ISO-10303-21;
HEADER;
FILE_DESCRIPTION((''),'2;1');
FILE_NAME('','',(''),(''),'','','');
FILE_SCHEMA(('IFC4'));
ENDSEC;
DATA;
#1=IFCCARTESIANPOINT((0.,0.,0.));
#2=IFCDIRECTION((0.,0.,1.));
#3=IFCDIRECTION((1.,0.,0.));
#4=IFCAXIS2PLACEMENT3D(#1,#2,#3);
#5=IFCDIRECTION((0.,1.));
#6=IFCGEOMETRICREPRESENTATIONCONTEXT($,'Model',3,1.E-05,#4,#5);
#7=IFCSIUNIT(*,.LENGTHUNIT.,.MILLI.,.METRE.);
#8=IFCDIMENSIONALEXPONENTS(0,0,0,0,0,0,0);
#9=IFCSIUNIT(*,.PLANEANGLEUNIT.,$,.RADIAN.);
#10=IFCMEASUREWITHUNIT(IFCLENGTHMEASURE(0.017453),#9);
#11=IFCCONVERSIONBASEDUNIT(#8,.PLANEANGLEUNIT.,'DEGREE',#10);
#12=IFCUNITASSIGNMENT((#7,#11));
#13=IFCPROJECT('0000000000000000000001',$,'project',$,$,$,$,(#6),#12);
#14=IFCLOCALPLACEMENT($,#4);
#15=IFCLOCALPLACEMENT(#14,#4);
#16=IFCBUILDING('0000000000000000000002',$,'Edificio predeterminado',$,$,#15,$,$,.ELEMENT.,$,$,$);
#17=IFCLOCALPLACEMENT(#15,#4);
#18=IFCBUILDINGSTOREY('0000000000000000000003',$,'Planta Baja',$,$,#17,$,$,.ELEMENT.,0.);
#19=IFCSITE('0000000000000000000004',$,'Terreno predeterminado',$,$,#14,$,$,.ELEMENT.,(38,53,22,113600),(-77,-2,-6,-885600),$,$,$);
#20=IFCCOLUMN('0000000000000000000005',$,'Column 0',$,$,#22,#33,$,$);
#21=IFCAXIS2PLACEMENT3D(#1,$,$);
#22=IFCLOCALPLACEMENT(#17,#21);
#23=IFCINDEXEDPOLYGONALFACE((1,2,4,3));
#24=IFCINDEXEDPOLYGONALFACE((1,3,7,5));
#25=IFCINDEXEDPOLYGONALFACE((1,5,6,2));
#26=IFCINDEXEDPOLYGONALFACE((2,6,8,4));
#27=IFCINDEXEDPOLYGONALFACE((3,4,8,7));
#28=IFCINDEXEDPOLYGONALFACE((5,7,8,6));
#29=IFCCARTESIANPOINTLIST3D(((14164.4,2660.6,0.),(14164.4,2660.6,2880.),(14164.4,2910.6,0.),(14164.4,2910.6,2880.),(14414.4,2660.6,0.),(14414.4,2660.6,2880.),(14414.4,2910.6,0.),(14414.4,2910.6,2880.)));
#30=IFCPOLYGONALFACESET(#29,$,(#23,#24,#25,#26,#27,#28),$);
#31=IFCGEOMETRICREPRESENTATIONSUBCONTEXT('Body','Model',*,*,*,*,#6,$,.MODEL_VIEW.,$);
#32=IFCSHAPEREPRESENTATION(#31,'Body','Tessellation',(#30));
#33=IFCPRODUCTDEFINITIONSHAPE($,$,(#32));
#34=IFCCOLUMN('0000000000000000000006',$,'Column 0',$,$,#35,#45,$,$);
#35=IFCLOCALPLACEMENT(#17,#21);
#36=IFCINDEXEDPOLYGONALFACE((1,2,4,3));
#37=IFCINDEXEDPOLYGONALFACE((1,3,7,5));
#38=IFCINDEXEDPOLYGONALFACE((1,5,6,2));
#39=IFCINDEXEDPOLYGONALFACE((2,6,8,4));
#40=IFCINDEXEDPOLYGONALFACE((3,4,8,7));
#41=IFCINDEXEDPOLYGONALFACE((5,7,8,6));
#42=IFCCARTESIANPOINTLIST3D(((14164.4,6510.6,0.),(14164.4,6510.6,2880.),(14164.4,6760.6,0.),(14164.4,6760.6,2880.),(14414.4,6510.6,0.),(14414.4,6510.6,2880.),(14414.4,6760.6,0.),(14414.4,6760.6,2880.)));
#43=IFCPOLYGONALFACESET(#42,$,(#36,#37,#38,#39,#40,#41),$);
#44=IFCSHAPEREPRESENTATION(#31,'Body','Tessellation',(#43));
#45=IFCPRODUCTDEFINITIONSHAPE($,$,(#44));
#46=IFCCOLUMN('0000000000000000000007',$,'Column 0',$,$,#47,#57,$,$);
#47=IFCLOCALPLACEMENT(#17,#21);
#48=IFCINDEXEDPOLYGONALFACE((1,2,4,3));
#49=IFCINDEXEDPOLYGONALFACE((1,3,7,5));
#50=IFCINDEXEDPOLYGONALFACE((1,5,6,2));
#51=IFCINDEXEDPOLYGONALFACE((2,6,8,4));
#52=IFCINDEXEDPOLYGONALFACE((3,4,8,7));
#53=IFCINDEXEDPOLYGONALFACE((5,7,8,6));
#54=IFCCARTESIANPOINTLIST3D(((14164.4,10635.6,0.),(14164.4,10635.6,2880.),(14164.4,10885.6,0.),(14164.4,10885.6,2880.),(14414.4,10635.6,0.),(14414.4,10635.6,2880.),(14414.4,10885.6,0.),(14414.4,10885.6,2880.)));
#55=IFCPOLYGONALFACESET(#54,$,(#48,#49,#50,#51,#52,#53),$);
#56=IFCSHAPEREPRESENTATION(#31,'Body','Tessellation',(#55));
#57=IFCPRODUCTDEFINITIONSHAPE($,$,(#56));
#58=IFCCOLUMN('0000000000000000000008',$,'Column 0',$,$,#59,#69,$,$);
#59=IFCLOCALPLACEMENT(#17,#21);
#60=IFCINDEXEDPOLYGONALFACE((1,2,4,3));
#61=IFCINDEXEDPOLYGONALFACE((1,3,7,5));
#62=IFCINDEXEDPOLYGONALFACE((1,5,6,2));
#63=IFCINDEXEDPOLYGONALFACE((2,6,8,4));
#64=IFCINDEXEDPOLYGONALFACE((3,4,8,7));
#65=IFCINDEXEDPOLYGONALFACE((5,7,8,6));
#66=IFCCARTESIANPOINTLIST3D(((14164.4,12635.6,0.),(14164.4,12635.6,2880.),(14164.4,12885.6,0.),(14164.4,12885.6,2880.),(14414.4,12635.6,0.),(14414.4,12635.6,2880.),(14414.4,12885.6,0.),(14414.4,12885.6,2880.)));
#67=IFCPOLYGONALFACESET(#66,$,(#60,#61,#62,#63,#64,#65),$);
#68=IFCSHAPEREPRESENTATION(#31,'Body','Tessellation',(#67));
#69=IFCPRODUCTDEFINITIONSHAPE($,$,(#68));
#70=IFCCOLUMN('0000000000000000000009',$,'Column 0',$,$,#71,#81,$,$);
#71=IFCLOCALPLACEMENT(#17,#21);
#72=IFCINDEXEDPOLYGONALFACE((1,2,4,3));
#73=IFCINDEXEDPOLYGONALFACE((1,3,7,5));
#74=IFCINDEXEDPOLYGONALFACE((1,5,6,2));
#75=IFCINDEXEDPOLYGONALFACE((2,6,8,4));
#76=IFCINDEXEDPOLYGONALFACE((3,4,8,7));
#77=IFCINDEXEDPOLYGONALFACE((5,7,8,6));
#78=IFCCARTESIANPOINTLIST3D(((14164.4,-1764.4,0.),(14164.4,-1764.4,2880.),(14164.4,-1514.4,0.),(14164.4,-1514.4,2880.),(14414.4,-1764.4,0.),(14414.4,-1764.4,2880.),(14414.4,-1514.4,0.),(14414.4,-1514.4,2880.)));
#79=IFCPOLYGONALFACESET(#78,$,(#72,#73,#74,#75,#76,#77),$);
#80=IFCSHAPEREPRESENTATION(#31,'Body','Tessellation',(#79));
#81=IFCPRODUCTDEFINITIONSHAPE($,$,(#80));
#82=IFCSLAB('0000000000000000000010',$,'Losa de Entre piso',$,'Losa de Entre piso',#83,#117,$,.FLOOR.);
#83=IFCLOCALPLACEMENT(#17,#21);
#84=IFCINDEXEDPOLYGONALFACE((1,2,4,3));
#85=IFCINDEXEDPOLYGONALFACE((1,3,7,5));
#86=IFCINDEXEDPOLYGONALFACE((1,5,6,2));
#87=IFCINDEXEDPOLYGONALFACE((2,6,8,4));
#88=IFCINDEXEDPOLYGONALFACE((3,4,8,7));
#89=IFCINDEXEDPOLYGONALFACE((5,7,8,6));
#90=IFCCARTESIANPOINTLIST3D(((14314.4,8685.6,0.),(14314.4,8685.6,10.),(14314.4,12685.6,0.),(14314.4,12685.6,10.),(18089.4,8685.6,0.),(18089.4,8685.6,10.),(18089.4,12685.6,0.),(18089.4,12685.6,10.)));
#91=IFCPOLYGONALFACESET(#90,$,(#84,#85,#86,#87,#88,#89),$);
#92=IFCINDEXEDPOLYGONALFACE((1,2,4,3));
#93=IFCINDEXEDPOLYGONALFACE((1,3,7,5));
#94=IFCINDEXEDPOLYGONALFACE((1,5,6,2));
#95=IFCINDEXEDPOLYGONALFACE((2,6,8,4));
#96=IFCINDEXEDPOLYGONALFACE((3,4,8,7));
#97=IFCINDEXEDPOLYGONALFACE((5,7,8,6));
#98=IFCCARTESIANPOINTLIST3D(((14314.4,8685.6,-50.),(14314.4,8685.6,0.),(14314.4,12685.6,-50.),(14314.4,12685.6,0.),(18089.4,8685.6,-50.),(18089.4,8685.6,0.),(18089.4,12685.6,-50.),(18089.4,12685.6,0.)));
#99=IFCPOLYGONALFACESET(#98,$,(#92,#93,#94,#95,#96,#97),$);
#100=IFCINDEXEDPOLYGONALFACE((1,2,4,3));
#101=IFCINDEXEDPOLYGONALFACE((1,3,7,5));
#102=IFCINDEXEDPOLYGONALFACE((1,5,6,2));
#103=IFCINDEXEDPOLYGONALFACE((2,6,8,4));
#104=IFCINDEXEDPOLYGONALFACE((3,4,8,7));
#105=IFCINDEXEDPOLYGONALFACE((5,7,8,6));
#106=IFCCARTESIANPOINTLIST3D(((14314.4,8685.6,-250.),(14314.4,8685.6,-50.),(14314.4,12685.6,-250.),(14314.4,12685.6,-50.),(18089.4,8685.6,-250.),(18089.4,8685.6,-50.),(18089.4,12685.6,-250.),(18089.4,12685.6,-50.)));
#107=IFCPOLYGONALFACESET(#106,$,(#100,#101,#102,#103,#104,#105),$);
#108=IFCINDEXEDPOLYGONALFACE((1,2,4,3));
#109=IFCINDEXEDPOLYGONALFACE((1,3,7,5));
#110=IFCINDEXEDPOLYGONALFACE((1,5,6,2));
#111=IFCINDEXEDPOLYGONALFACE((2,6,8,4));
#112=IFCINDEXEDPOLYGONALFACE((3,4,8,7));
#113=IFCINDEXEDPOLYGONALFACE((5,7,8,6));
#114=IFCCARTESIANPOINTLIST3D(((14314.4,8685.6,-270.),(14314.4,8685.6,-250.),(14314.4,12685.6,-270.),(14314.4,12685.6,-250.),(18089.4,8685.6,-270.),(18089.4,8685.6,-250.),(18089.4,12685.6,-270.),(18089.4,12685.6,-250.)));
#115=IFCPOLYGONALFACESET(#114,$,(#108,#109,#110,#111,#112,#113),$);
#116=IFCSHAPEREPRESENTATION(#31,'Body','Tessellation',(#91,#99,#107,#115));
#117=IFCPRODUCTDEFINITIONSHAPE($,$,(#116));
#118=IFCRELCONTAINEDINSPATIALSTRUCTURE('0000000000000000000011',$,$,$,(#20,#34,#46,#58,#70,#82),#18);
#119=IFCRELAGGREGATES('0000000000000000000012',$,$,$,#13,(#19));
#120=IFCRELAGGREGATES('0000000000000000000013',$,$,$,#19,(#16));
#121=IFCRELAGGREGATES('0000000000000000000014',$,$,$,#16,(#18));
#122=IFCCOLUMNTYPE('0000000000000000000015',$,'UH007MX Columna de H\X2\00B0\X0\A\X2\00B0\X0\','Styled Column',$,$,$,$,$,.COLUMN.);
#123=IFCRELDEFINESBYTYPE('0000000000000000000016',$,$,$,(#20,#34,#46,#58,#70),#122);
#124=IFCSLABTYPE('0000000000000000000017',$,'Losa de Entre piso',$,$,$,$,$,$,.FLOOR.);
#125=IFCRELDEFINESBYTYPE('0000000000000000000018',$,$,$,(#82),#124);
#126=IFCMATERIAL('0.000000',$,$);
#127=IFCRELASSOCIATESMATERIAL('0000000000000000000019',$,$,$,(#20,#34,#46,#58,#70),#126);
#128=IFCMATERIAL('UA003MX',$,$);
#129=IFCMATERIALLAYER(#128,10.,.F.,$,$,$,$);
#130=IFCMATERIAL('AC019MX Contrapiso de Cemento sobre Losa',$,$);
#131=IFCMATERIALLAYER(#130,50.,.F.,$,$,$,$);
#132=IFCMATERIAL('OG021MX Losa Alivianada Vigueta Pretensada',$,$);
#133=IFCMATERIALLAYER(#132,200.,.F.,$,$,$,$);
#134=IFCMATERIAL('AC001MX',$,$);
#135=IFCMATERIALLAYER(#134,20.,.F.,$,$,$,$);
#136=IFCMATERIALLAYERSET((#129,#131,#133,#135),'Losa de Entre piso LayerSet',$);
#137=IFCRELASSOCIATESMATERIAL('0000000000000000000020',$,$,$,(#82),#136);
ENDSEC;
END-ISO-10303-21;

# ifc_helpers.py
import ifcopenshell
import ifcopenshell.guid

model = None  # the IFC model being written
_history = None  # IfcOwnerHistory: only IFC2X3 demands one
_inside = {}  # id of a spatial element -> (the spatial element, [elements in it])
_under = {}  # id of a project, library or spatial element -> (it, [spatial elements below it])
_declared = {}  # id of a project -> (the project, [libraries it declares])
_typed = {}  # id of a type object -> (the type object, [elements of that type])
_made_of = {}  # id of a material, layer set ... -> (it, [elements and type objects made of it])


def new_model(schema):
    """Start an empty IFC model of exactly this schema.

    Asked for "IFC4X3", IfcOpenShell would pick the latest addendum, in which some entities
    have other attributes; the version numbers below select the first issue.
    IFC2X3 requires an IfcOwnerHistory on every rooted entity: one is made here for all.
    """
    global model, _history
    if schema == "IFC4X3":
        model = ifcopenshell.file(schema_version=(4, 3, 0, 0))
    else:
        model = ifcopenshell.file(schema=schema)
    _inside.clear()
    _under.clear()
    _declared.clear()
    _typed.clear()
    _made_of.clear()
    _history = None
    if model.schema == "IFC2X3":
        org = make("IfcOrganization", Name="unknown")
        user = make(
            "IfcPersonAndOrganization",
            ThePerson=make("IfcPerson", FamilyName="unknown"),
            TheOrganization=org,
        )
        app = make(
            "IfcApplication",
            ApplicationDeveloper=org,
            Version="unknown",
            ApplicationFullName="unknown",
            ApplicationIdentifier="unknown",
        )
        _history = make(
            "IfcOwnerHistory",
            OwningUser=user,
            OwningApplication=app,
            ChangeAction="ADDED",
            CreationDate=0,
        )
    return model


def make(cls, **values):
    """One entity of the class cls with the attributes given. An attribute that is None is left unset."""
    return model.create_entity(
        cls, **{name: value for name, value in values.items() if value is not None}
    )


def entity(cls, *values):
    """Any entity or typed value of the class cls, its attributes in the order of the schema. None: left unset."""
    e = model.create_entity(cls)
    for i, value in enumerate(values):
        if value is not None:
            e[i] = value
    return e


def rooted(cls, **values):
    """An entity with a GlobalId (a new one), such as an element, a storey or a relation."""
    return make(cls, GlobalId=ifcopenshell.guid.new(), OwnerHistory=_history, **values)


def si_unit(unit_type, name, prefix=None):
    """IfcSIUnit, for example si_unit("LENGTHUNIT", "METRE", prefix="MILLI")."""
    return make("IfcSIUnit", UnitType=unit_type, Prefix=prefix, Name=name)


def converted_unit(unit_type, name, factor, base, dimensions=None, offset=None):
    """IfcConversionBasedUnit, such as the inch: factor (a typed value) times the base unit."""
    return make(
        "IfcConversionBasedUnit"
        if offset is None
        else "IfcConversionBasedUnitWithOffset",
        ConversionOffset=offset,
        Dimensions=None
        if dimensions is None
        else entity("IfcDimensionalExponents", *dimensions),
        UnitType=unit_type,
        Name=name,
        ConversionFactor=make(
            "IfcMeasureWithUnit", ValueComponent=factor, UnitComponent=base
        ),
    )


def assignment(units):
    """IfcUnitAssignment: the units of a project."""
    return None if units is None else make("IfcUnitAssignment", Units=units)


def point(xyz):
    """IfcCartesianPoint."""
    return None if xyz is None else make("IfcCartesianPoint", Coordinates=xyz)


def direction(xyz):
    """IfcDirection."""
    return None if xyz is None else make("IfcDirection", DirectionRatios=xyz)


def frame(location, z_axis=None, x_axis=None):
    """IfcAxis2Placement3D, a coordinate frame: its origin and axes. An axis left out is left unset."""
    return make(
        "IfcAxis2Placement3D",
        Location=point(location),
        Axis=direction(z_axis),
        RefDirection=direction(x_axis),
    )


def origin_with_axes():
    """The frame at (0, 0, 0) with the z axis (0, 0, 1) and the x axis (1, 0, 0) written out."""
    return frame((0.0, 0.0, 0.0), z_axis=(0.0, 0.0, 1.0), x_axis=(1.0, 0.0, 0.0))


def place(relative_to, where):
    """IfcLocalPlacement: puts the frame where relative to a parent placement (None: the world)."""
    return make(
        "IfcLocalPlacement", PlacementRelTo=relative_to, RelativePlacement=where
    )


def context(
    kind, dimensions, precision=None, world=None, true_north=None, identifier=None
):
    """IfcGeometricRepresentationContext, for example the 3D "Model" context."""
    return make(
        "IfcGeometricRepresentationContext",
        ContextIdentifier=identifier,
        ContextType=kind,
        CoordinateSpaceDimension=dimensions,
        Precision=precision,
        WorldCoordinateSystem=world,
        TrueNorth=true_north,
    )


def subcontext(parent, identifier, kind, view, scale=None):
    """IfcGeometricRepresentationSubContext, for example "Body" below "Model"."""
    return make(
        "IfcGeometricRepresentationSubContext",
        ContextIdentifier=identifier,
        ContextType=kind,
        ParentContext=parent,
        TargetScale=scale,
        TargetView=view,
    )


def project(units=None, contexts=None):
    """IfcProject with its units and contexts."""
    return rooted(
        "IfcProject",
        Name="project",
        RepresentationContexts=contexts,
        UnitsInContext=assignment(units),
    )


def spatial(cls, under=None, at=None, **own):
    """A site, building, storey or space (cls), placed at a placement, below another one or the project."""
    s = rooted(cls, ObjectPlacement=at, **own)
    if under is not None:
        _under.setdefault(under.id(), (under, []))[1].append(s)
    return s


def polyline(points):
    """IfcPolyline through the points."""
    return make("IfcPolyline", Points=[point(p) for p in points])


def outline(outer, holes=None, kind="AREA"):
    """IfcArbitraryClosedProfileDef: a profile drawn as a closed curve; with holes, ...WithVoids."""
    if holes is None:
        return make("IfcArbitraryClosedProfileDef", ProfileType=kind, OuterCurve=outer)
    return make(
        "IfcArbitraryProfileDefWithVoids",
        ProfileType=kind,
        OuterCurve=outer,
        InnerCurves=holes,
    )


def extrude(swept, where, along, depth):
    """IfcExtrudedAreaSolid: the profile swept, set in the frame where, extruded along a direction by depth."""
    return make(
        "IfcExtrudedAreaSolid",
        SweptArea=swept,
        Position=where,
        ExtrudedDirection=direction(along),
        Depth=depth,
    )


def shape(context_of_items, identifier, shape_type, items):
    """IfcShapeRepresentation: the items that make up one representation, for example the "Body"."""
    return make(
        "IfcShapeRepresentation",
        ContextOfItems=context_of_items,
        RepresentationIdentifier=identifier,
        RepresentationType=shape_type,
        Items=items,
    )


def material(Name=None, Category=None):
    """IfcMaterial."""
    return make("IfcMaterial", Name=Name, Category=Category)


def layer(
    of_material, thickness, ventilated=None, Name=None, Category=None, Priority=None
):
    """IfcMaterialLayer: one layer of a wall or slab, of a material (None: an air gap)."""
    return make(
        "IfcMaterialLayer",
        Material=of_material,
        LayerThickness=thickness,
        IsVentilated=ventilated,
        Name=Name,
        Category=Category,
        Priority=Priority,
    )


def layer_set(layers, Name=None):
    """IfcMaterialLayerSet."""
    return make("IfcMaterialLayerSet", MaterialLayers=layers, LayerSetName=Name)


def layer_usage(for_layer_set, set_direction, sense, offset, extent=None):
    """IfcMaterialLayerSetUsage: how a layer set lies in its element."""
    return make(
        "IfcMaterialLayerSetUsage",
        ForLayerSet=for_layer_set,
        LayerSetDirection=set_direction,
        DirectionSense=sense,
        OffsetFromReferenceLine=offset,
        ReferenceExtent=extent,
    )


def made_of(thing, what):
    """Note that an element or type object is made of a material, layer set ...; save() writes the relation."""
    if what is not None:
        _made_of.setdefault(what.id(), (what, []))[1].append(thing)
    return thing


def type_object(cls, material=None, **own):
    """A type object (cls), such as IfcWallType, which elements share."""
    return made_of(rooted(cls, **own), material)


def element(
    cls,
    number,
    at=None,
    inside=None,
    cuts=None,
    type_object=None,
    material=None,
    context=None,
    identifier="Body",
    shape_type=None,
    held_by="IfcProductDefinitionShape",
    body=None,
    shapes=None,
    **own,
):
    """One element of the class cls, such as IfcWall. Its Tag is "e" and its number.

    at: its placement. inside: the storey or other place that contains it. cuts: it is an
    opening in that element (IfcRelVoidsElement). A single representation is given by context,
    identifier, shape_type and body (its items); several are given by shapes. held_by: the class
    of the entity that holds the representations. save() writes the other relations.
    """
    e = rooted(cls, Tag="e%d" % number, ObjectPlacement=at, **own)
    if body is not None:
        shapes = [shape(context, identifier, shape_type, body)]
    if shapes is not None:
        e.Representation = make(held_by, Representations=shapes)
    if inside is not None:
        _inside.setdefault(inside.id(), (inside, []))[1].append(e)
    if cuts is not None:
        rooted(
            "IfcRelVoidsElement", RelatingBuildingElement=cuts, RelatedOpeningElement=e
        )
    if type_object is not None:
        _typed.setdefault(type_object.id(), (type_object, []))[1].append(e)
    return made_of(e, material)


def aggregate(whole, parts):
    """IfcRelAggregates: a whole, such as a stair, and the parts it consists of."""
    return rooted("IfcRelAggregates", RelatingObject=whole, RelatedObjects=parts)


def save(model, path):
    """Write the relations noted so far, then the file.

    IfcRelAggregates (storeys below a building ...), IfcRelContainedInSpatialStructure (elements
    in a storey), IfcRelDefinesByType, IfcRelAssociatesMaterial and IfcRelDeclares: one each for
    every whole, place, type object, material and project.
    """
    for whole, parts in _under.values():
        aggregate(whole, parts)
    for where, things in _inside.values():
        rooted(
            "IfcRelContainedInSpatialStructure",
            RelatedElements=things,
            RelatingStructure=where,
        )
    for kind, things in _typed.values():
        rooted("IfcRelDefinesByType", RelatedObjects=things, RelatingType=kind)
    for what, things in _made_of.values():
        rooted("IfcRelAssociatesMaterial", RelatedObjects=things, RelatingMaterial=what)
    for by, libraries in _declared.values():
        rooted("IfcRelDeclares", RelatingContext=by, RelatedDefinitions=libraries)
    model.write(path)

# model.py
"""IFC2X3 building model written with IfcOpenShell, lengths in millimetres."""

from ifc_helpers import new_model, entity, si_unit, converted_unit, direction, frame, origin_with_axes, place, context, subcontext, project, spatial, polyline, outline, extrude, material, layer, layer_set, layer_usage, type_object, element, save


model = new_model("IFC2X3")

# Units and contexts
model_context = context("Model", 3, precision=1e-05, world=origin_with_axes(), true_north=direction((0.0, 1.0)))
body_context = subcontext(model_context, "Body", "Model", "MODEL_VIEW")
ifc_project = project(units=[si_unit("LENGTHUNIT", "METRE", prefix="MILLI"), converted_unit("PLANEANGLEUNIT", "DEGREE", entity("IfcLengthMeasure", 0.017453), si_unit("PLANEANGLEUNIT", "RADIAN"), dimensions=[0, 0, 0, 0, 0, 0, 0])], contexts=[model_context])

# Site, building, storey
site_placement = place(None, origin_with_axes())
site = spatial("IfcSite", under=ifc_project, at=site_placement, Name="Terreno predeterminado", CompositionType="ELEMENT", RefLatitude=(38, 53, 22, 113600), RefLongitude=(-77, -2, -6, -885600))
building_placement = place(site_placement, origin_with_axes())
building = spatial("IfcBuilding", under=site, at=building_placement, Name="Edificio predeterminado", CompositionType="ELEMENT")
storey_placement = place(building_placement, origin_with_axes())
storey = spatial("IfcBuildingStorey", under=building, at=storey_placement, Name="Planta Baja", CompositionType="ELEMENT", Elevation=0.0)

# Columns
ifc_material_1 = material(Name="0.000000")
column_type = type_object("IfcColumnType", Name="UH007MX Columna de H°A°", Description="Styled Column", PredefinedType="COLUMN")
for number, where, z_axis, x_axis, name in (
    (1, (14289.4, 2785.6, 0.0), (0.0, 0.0, 1.0), (1.0, 0.0, 0.0), "Column 0"),
    (2, (14289.4, 6635.6, 0.0), (0.0, 0.0, 1.0), (1.0, 0.0, 0.0), "Column 0"),
    (3, (14289.4, 10760.6, 0.0), (0.0, 0.0, 1.0), (1.0, 0.0, 0.0), "Column 0"),
    (4, (14289.4, 12760.6, 0.0), (0.0, 0.0, 1.0), (1.0, 0.0, 0.0), "Column 0"),
    (5, (14289.4, -1639.4, 0.0), (0.0, 0.0, 1.0), (1.0, 0.0, 0.0), "Column 0"),
):
    element("IfcColumn", number, at=place(storey_placement, frame(where, z_axis=z_axis, x_axis=x_axis)), inside=storey, type_object=column_type, material=ifc_material_1, Name=name, context=body_context, shape_type="SweptSolid", body=[
        extrude(outline(polyline([(-125.0, -125.0), (125.0, -125.0), (125.0, 125.0), (-125.0, 125.0), (-125.0, -125.0)])), origin_with_axes(), (0.0, 0.0, 1.0), 2880.0),
    ])

# Slab
ifc_material_2 = material(Name="UA003MX")
ifc_layer_1 = layer(ifc_material_2, 10.0, ventilated=False)
ifc_material_3 = material(Name="AC019MX Contrapiso de Cemento sobre Losa")
ifc_layer_2 = layer(ifc_material_3, 50.0, ventilated=False)
ifc_material_4 = material(Name="OG021MX Losa Alivianada Vigueta Pretensada")
ifc_layer_3 = layer(ifc_material_4, 200.0, ventilated=False)
ifc_material_5 = material(Name="AC001MX")
ifc_layer_4 = layer(ifc_material_5, 20.0, ventilated=False)
ifc_layer_set_1 = layer_set([ifc_layer_1, ifc_layer_2, ifc_layer_3, ifc_layer_4], Name="Losa de Entre piso LayerSet")
ifc_layer_usage_1 = layer_usage(ifc_layer_set_1, "AXIS3", "NEGATIVE", 0.0)
slab_type = type_object("IfcSlabType", Name="Losa de Entre piso", PredefinedType="FLOOR")
slab_1_placement = place(storey_placement, origin_with_axes())
element("IfcSlab", 6, at=slab_1_placement, inside=storey, type_object=slab_type, material=ifc_layer_usage_1, Name="Losa de Entre piso", ObjectType="Losa de Entre piso", PredefinedType="FLOOR", context=body_context, shape_type="SweptSolid", body=[
    extrude(outline(polyline([(0.0, 4000.0), (3775.0, 4000.0), (3775.0, 0.0), (0.0, 0.0), (0.0, 4000.0)])), frame((14314.4, 12685.6, 0.0), z_axis=(0.0, 0.0, -1.0), x_axis=(1.0, 0.0, 0.0)), (0.0, 0.0, -1.0), 10.0),
    extrude(outline(polyline([(0.0, 4000.0), (3775.0, 4000.0), (3775.0, 0.0), (0.0, 0.0), (0.0, 4000.0)])), frame((14314.4, 12685.6, -50.0), z_axis=(0.0, 0.0, -1.0), x_axis=(1.0, 0.0, 0.0)), (0.0, 0.0, -1.0), 50.0),
    extrude(outline(polyline([(0.0, 4000.0), (3775.0, 4000.0), (3775.0, 0.0), (0.0, 0.0), (0.0, 4000.0)])), frame((14314.4, 12685.6, -250.0), z_axis=(0.0, 0.0, -1.0), x_axis=(1.0, 0.0, 0.0)), (0.0, 0.0, -1.0), 200.0),
    extrude(outline(polyline([(0.0, 4000.0), (3775.0, 4000.0), (3775.0, 0.0), (0.0, 0.0), (0.0, 4000.0)])), frame((14314.4, 12685.6, -270.0), z_axis=(0.0, 0.0, -1.0), x_axis=(1.0, 0.0, 0.0)), (0.0, 0.0, -1.0), 20.0),
])

save(model, "model.ifc")
